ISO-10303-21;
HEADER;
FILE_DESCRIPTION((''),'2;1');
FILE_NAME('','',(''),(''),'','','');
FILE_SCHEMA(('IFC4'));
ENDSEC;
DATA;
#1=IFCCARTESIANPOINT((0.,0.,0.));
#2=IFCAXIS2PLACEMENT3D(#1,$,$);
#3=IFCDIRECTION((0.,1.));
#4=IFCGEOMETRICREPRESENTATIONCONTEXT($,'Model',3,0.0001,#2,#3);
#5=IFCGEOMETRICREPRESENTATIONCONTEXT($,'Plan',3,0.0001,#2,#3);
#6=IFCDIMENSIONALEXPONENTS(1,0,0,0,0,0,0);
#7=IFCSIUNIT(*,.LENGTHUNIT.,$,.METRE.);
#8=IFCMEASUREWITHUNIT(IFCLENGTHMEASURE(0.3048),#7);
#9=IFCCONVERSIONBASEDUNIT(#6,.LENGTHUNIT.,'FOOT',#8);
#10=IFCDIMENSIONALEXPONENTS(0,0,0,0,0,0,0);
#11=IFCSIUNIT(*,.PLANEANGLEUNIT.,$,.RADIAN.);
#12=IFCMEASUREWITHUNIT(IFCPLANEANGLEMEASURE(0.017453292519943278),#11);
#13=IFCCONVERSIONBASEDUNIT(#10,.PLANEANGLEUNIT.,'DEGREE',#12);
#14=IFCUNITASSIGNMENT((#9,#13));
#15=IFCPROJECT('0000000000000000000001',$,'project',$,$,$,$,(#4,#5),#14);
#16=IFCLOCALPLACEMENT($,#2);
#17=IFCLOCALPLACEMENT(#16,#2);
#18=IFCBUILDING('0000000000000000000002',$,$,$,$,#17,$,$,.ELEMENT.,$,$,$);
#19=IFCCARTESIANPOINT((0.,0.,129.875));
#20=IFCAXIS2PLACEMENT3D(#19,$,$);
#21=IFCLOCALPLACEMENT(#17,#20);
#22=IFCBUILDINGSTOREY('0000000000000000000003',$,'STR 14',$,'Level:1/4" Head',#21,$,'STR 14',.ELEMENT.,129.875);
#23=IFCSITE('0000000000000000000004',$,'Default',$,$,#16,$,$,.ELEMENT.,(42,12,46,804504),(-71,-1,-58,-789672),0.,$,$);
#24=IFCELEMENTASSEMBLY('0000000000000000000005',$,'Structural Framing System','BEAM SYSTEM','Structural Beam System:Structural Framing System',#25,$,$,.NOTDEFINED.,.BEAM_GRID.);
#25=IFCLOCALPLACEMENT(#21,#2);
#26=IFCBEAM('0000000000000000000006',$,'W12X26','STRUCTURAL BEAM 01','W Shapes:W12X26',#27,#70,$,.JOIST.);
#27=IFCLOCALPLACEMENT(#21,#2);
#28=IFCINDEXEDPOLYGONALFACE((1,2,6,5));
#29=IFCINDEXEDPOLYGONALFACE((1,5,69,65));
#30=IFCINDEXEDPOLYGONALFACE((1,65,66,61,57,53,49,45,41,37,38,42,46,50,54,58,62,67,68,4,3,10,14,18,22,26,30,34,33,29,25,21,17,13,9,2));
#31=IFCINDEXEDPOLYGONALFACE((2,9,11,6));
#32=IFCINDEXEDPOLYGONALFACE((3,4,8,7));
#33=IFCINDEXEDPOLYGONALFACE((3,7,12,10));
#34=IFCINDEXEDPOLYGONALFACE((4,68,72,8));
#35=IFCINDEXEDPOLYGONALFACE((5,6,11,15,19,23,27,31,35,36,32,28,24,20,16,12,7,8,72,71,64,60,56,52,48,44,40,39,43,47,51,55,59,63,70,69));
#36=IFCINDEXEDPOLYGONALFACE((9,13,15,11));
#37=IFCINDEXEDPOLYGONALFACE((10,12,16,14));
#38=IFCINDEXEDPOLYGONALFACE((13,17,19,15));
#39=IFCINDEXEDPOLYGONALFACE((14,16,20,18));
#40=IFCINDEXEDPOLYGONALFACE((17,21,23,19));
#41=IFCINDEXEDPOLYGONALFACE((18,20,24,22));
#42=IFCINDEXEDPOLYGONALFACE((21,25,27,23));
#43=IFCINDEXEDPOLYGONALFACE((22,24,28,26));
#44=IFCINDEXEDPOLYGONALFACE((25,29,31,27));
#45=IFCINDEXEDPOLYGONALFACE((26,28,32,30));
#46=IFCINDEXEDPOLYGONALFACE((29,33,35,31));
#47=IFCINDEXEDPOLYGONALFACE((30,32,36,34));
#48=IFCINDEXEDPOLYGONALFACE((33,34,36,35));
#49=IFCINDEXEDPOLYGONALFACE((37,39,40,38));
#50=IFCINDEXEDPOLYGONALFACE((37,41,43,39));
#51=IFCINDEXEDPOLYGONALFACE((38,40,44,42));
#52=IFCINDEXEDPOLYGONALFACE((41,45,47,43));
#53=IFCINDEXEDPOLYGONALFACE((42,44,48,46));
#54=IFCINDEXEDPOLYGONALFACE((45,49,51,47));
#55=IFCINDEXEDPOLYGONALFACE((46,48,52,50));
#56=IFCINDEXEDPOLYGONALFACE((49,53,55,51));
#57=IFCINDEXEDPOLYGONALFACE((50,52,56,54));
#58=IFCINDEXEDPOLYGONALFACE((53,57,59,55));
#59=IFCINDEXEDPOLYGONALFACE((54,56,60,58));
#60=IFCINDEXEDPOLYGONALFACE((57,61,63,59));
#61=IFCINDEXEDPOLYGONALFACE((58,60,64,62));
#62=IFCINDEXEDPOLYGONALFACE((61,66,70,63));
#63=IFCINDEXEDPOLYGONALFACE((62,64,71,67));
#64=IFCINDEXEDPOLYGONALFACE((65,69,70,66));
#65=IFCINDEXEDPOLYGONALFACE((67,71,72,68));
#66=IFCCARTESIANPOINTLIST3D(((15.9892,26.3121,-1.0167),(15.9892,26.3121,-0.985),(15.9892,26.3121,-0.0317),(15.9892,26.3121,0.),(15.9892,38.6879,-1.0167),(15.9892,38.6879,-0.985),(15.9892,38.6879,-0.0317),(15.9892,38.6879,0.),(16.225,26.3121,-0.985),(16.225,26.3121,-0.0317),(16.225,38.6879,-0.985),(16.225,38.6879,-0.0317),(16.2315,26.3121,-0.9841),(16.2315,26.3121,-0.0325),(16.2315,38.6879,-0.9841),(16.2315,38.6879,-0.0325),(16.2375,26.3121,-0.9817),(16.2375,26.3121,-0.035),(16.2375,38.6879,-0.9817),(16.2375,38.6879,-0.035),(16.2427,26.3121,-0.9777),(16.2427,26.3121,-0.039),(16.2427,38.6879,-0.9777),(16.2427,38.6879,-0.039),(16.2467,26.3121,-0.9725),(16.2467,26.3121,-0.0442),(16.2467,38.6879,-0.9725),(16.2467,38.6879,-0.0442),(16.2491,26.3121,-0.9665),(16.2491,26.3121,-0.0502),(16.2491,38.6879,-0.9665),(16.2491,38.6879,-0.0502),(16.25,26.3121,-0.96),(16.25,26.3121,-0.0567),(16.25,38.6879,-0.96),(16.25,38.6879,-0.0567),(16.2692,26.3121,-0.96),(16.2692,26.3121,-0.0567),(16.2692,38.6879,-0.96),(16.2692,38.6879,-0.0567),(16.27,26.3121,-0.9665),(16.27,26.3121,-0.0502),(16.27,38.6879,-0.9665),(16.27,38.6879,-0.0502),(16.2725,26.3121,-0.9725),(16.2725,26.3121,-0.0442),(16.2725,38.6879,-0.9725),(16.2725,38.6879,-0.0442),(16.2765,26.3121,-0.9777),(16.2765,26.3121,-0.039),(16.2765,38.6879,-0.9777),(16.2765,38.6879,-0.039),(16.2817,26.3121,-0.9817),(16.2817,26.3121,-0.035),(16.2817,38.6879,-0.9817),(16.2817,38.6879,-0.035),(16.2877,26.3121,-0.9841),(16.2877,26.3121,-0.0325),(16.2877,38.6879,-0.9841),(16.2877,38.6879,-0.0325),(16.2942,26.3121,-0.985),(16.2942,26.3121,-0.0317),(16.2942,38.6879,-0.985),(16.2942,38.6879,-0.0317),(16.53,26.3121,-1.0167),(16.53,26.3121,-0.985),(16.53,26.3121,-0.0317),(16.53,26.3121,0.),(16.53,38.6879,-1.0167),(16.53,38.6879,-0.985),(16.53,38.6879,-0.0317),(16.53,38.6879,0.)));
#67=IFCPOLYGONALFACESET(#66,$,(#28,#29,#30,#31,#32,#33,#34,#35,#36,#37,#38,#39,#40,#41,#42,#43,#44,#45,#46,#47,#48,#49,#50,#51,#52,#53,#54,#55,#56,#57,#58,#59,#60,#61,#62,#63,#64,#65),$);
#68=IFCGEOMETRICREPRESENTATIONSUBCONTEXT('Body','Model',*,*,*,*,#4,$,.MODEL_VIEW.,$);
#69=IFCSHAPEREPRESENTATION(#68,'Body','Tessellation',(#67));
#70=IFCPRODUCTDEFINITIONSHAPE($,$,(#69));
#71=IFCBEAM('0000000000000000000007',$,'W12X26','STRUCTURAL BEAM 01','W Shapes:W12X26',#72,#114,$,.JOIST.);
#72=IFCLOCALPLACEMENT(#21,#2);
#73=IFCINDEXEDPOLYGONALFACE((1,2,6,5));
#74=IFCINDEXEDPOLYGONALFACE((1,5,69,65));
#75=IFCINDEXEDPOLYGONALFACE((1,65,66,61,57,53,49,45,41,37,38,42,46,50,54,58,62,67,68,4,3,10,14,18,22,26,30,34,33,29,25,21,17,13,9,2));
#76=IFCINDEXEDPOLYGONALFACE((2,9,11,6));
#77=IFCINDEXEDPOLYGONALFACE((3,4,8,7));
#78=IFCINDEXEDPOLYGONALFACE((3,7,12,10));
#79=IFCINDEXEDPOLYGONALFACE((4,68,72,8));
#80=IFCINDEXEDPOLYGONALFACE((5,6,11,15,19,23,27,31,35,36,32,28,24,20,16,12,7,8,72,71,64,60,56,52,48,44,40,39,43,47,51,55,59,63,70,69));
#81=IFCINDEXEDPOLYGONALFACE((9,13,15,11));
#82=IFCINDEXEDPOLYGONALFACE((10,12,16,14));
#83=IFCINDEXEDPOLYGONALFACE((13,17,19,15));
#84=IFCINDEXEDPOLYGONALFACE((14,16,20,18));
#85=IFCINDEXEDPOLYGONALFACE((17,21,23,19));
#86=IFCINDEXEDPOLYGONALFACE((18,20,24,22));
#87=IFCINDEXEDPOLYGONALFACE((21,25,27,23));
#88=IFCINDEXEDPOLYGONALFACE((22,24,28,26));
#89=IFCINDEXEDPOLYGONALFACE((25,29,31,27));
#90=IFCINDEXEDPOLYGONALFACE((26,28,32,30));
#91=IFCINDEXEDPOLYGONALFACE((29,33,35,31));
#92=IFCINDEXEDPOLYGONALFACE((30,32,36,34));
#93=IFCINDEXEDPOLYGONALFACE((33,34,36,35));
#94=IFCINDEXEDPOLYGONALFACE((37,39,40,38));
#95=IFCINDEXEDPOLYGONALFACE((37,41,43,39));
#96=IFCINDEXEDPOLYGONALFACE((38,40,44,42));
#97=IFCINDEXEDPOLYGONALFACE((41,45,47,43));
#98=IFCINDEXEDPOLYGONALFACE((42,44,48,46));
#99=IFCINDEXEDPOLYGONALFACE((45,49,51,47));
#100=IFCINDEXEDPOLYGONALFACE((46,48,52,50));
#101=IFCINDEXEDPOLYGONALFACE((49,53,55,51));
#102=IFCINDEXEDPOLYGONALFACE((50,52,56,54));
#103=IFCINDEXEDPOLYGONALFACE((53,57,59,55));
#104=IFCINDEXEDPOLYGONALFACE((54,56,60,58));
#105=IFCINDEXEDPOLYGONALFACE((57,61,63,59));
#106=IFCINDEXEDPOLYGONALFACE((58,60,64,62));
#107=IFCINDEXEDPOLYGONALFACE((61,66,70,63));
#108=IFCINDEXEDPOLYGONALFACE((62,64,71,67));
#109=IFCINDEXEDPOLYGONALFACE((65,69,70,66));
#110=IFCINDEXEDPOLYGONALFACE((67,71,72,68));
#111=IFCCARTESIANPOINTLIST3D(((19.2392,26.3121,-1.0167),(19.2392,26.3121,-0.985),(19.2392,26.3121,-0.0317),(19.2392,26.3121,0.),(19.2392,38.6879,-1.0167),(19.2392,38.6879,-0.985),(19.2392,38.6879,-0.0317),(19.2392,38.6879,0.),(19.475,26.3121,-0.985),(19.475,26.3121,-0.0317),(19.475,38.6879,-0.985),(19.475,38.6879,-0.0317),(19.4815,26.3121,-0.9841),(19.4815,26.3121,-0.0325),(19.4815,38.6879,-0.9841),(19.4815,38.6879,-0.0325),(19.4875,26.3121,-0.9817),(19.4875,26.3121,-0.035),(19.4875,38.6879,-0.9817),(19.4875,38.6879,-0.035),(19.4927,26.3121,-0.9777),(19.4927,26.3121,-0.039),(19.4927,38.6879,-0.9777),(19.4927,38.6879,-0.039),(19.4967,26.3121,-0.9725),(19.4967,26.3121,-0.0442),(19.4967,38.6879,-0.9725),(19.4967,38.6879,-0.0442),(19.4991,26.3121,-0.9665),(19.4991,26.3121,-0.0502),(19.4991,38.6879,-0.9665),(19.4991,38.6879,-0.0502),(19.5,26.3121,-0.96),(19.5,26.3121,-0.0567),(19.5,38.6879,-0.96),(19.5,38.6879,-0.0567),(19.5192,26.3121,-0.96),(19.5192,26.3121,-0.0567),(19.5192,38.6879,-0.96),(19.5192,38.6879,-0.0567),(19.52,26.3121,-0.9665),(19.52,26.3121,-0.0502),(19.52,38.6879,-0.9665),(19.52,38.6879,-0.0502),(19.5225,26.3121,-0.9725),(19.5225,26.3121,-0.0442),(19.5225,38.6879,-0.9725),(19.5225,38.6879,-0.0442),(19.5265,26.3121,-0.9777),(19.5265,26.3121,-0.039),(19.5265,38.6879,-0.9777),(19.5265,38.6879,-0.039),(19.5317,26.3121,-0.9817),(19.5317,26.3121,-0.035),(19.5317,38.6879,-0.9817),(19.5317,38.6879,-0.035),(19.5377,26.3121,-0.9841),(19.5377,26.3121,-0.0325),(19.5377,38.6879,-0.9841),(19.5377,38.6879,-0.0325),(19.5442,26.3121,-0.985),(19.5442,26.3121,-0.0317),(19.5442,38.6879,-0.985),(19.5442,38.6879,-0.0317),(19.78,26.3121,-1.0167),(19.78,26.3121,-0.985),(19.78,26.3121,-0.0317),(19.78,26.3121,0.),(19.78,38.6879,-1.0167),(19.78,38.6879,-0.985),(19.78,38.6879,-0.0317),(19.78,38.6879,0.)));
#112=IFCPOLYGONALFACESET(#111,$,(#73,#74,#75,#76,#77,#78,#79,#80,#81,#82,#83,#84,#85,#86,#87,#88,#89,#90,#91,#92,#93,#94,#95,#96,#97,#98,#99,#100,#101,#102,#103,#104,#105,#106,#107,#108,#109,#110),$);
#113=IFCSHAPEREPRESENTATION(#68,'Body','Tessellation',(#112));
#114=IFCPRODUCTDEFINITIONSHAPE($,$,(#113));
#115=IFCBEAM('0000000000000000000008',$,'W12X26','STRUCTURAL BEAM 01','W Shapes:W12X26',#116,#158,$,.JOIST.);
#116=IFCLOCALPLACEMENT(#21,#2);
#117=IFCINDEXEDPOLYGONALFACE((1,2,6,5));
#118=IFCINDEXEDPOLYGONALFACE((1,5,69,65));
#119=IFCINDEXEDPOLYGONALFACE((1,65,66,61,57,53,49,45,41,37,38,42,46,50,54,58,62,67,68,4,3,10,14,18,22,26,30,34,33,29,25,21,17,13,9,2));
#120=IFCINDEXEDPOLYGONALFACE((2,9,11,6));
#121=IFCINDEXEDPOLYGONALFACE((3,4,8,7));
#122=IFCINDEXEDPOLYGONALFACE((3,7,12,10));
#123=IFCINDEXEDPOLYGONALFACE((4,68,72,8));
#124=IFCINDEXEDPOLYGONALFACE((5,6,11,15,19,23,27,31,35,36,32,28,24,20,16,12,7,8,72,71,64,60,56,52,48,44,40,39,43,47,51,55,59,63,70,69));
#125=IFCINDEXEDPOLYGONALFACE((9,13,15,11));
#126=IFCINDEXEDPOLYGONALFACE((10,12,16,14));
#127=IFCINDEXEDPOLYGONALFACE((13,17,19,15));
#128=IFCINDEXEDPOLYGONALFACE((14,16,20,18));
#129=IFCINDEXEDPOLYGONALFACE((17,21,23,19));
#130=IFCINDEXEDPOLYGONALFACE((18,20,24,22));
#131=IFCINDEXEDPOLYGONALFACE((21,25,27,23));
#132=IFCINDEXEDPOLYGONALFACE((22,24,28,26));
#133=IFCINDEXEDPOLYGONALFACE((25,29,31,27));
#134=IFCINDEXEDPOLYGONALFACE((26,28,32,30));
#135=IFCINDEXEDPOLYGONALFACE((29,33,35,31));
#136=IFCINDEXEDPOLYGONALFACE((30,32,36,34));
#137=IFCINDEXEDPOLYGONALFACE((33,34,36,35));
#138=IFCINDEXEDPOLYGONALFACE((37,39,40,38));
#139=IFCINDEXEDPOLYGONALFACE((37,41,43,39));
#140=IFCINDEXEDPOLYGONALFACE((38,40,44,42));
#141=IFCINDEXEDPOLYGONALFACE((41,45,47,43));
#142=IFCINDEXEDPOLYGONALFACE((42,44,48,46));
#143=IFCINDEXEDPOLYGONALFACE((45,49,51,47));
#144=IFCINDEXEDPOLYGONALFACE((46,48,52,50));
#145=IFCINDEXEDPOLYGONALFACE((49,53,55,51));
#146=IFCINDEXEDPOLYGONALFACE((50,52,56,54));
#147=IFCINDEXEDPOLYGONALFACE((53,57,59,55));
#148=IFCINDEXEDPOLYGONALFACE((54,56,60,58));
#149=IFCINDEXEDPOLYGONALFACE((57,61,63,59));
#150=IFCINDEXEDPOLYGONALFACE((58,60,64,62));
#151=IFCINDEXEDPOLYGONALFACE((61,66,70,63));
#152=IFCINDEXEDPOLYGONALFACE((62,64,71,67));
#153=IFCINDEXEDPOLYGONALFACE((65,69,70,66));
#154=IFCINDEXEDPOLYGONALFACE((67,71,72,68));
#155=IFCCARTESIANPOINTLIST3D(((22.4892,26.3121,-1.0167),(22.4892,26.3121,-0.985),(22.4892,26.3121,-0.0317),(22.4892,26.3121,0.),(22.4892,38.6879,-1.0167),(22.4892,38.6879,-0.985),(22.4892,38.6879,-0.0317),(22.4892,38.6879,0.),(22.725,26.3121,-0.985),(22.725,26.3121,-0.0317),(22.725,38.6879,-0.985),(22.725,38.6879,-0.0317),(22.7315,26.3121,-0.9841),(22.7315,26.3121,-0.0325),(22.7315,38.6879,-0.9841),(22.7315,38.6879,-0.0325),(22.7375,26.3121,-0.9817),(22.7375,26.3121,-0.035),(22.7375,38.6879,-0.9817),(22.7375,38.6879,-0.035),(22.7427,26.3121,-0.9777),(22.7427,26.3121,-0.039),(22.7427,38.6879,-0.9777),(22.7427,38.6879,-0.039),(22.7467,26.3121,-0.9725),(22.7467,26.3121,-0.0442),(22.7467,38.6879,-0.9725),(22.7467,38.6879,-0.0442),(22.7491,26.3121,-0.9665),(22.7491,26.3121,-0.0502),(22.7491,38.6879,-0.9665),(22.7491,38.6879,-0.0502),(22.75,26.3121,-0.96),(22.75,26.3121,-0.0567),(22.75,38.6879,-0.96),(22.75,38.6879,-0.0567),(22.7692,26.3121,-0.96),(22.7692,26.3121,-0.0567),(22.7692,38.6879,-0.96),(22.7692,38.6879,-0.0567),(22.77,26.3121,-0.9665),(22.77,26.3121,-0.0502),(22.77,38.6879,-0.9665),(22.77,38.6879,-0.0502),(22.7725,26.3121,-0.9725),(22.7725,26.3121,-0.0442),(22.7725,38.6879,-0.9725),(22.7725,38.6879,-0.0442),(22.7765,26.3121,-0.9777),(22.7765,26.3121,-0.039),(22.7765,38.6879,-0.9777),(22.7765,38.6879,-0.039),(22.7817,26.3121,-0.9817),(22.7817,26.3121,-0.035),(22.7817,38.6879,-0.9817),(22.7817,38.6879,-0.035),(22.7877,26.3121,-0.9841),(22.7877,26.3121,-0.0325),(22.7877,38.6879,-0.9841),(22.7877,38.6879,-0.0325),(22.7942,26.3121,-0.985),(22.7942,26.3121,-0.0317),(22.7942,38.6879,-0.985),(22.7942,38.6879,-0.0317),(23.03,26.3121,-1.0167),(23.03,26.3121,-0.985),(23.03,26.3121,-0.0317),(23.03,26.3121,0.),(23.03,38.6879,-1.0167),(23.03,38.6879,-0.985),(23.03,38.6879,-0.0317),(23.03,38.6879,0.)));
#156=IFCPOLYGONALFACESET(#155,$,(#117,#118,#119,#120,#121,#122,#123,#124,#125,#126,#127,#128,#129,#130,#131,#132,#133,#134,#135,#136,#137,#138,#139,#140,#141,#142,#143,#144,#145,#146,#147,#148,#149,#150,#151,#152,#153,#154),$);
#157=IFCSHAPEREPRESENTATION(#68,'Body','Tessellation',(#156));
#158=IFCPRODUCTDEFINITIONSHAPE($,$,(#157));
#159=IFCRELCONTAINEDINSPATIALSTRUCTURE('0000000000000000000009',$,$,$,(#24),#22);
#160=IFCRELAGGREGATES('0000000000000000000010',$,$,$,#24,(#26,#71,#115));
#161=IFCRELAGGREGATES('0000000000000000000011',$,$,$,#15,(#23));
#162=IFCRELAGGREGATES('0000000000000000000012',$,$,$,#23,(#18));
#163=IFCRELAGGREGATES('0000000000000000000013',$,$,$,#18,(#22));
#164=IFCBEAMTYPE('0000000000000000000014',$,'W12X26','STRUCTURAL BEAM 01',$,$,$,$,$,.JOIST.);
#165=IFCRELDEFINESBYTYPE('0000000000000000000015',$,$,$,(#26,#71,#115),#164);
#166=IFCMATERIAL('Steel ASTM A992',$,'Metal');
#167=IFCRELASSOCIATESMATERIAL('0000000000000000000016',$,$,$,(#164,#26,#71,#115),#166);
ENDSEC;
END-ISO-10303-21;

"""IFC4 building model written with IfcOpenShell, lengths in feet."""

from ifc_helpers import new_model, entity, si_unit, converted_unit, direction, frame, origin, place, context, subcontext, project, spatial, line, arc, indexed_curve, outline, extrude, source, transform, mapped, material, type_object, type_shapes, element, aggregate, save


model = new_model("IFC4")

# Units and contexts
model_context = context("Model", 3, precision=0.0001, world=origin(), true_north=direction((0.0, 1.0)))
plan_context = context("Plan", 3, precision=0.0001, world=origin(), true_north=direction((0.0, 1.0)))
body_context = subcontext(model_context, "Body", "Model", "MODEL_VIEW")
ifc_project = project(units=[converted_unit("LENGTHUNIT", "FOOT", entity("IfcLengthMeasure", 0.3048), si_unit("LENGTHUNIT", "METRE"), dimensions=[1, 0, 0, 0, 0, 0, 0]), converted_unit("PLANEANGLEUNIT", "DEGREE", entity("IfcPlaneAngleMeasure", 0.017453292519943278), si_unit("PLANEANGLEUNIT", "RADIAN"), dimensions=[0, 0, 0, 0, 0, 0, 0])], contexts=[model_context, plan_context])

# Site, building, storey
site_placement = place(None, origin())
site = spatial("IfcSite", under=ifc_project, at=site_placement, Name="Default", CompositionType="ELEMENT", RefLatitude=(42, 12, 46, 804504), RefLongitude=(-71, -1, -58, -789672), RefElevation=0.0)
building_placement = place(site_placement, origin())
building = spatial("IfcBuilding", under=site, at=building_placement, CompositionType="ELEMENT")
storey_placement = place(building_placement, frame((0.0, 0.0, 129.875)))
storey = spatial("IfcBuildingStorey", under=building, at=storey_placement, Name="STR 14", ObjectType="Level:1/4\" Head", LongName="STR 14", CompositionType="ELEMENT", Elevation=129.875)

# Shared definitions
ifc_material = material(Name="Steel ASTM A992", Category="Metal")

# Element assembly, beams
beam_type_1 = type_object("IfcBeamType", Name="W12X26", Description="STRUCTURAL BEAM 01", PredefinedType="JOIST", material=ifc_material)
shared_shape_1 = source(origin(), body_context, "Body", "SweptSolid", [
    extrude(outline(indexed_curve([(-0.2704, -0.4767), (-0.2704, -0.5083), (0.2704, -0.5083), (0.2704, -0.4767), (0.0346, -0.4767), (0.0169, -0.4693), (0.0096, -0.4517), (0.0096, 0.4517), (0.0169, 0.4693), (0.0346, 0.4767), (0.2704, 0.4767), (0.2704, 0.5083), (-0.2704, 0.5083), (-0.2704, 0.4767), (-0.0346, 0.4767), (-0.0169, 0.4693), (-0.0096, 0.4517), (-0.0096, -0.4517), (-0.0169, -0.4693), (-0.0346, -0.4767)], segments=[line(1, 2, 3, 4, 5), arc(5, 6, 7), line(7, 8), arc(8, 9, 10), line(10, 11, 12, 13, 14, 15), arc(15, 16, 17), line(17, 18), arc(18, 19, 20), line(20, 1)], self_intersect=False)), frame((-6.1879, 0.0, 0.0), z_axis=(-1.0, 0.0, 0.0), x_axis=(0.0, -1.0, 0.0)), (0.0, 0.0, -1.0), 12.3758),
])
type_shapes(beam_type_1, [shared_shape_1])
assembly_1_placement = place(storey_placement, origin())
assembly_1 = element("IfcElementAssembly", 1, at=assembly_1_placement, inside=storey, Name="Structural Framing System", Description="BEAM SYSTEM", ObjectType="Structural Beam System:Structural Framing System", AssemblyPlace="NOTDEFINED", PredefinedType="BEAM_GRID")
beam_1_placement = place(assembly_1_placement, frame((16.2596, 32.5, -0.5083), z_axis=(0.0, 0.0, 1.0), x_axis=(0.0, 1.0, 0.0)))
beam_1 = element("IfcBeam", 2, at=beam_1_placement, type_object=beam_type_1, material=ifc_material, Name="W12X26", Description="STRUCTURAL BEAM 01", ObjectType="W Shapes:W12X26", PredefinedType="JOIST", context=body_context, shape_type="MappedRepresentation", body=[
    mapped(shared_shape_1, transform((0.0, 0.0, 0.0), scale=1.0)),
])
beam_2_placement = place(assembly_1_placement, frame((19.5096, 32.5, -0.5083), z_axis=(0.0, 0.0, 1.0), x_axis=(0.0, 1.0, 0.0)))
beam_2 = element("IfcBeam", 3, at=beam_2_placement, type_object=beam_type_1, material=ifc_material, Name="W12X26", Description="STRUCTURAL BEAM 01", ObjectType="W Shapes:W12X26", PredefinedType="JOIST", context=body_context, shape_type="MappedRepresentation", body=[
    mapped(shared_shape_1, transform((0.0, 0.0, 0.0), scale=1.0)),
])
beam_3_placement = place(assembly_1_placement, frame((22.7596, 32.5, -0.5083), z_axis=(0.0, 0.0, 1.0), x_axis=(0.0, 1.0, 0.0)))
beam_3 = element("IfcBeam", 4, at=beam_3_placement, type_object=beam_type_1, material=ifc_material, Name="W12X26", Description="STRUCTURAL BEAM 01", ObjectType="W Shapes:W12X26", PredefinedType="JOIST", context=body_context, shape_type="MappedRepresentation", body=[
    mapped(shared_shape_1, transform((0.0, 0.0, 0.0), scale=1.0)),
])
aggregate(assembly_1, [beam_1, beam_2, beam_3])

save(model, "model.ifc")
